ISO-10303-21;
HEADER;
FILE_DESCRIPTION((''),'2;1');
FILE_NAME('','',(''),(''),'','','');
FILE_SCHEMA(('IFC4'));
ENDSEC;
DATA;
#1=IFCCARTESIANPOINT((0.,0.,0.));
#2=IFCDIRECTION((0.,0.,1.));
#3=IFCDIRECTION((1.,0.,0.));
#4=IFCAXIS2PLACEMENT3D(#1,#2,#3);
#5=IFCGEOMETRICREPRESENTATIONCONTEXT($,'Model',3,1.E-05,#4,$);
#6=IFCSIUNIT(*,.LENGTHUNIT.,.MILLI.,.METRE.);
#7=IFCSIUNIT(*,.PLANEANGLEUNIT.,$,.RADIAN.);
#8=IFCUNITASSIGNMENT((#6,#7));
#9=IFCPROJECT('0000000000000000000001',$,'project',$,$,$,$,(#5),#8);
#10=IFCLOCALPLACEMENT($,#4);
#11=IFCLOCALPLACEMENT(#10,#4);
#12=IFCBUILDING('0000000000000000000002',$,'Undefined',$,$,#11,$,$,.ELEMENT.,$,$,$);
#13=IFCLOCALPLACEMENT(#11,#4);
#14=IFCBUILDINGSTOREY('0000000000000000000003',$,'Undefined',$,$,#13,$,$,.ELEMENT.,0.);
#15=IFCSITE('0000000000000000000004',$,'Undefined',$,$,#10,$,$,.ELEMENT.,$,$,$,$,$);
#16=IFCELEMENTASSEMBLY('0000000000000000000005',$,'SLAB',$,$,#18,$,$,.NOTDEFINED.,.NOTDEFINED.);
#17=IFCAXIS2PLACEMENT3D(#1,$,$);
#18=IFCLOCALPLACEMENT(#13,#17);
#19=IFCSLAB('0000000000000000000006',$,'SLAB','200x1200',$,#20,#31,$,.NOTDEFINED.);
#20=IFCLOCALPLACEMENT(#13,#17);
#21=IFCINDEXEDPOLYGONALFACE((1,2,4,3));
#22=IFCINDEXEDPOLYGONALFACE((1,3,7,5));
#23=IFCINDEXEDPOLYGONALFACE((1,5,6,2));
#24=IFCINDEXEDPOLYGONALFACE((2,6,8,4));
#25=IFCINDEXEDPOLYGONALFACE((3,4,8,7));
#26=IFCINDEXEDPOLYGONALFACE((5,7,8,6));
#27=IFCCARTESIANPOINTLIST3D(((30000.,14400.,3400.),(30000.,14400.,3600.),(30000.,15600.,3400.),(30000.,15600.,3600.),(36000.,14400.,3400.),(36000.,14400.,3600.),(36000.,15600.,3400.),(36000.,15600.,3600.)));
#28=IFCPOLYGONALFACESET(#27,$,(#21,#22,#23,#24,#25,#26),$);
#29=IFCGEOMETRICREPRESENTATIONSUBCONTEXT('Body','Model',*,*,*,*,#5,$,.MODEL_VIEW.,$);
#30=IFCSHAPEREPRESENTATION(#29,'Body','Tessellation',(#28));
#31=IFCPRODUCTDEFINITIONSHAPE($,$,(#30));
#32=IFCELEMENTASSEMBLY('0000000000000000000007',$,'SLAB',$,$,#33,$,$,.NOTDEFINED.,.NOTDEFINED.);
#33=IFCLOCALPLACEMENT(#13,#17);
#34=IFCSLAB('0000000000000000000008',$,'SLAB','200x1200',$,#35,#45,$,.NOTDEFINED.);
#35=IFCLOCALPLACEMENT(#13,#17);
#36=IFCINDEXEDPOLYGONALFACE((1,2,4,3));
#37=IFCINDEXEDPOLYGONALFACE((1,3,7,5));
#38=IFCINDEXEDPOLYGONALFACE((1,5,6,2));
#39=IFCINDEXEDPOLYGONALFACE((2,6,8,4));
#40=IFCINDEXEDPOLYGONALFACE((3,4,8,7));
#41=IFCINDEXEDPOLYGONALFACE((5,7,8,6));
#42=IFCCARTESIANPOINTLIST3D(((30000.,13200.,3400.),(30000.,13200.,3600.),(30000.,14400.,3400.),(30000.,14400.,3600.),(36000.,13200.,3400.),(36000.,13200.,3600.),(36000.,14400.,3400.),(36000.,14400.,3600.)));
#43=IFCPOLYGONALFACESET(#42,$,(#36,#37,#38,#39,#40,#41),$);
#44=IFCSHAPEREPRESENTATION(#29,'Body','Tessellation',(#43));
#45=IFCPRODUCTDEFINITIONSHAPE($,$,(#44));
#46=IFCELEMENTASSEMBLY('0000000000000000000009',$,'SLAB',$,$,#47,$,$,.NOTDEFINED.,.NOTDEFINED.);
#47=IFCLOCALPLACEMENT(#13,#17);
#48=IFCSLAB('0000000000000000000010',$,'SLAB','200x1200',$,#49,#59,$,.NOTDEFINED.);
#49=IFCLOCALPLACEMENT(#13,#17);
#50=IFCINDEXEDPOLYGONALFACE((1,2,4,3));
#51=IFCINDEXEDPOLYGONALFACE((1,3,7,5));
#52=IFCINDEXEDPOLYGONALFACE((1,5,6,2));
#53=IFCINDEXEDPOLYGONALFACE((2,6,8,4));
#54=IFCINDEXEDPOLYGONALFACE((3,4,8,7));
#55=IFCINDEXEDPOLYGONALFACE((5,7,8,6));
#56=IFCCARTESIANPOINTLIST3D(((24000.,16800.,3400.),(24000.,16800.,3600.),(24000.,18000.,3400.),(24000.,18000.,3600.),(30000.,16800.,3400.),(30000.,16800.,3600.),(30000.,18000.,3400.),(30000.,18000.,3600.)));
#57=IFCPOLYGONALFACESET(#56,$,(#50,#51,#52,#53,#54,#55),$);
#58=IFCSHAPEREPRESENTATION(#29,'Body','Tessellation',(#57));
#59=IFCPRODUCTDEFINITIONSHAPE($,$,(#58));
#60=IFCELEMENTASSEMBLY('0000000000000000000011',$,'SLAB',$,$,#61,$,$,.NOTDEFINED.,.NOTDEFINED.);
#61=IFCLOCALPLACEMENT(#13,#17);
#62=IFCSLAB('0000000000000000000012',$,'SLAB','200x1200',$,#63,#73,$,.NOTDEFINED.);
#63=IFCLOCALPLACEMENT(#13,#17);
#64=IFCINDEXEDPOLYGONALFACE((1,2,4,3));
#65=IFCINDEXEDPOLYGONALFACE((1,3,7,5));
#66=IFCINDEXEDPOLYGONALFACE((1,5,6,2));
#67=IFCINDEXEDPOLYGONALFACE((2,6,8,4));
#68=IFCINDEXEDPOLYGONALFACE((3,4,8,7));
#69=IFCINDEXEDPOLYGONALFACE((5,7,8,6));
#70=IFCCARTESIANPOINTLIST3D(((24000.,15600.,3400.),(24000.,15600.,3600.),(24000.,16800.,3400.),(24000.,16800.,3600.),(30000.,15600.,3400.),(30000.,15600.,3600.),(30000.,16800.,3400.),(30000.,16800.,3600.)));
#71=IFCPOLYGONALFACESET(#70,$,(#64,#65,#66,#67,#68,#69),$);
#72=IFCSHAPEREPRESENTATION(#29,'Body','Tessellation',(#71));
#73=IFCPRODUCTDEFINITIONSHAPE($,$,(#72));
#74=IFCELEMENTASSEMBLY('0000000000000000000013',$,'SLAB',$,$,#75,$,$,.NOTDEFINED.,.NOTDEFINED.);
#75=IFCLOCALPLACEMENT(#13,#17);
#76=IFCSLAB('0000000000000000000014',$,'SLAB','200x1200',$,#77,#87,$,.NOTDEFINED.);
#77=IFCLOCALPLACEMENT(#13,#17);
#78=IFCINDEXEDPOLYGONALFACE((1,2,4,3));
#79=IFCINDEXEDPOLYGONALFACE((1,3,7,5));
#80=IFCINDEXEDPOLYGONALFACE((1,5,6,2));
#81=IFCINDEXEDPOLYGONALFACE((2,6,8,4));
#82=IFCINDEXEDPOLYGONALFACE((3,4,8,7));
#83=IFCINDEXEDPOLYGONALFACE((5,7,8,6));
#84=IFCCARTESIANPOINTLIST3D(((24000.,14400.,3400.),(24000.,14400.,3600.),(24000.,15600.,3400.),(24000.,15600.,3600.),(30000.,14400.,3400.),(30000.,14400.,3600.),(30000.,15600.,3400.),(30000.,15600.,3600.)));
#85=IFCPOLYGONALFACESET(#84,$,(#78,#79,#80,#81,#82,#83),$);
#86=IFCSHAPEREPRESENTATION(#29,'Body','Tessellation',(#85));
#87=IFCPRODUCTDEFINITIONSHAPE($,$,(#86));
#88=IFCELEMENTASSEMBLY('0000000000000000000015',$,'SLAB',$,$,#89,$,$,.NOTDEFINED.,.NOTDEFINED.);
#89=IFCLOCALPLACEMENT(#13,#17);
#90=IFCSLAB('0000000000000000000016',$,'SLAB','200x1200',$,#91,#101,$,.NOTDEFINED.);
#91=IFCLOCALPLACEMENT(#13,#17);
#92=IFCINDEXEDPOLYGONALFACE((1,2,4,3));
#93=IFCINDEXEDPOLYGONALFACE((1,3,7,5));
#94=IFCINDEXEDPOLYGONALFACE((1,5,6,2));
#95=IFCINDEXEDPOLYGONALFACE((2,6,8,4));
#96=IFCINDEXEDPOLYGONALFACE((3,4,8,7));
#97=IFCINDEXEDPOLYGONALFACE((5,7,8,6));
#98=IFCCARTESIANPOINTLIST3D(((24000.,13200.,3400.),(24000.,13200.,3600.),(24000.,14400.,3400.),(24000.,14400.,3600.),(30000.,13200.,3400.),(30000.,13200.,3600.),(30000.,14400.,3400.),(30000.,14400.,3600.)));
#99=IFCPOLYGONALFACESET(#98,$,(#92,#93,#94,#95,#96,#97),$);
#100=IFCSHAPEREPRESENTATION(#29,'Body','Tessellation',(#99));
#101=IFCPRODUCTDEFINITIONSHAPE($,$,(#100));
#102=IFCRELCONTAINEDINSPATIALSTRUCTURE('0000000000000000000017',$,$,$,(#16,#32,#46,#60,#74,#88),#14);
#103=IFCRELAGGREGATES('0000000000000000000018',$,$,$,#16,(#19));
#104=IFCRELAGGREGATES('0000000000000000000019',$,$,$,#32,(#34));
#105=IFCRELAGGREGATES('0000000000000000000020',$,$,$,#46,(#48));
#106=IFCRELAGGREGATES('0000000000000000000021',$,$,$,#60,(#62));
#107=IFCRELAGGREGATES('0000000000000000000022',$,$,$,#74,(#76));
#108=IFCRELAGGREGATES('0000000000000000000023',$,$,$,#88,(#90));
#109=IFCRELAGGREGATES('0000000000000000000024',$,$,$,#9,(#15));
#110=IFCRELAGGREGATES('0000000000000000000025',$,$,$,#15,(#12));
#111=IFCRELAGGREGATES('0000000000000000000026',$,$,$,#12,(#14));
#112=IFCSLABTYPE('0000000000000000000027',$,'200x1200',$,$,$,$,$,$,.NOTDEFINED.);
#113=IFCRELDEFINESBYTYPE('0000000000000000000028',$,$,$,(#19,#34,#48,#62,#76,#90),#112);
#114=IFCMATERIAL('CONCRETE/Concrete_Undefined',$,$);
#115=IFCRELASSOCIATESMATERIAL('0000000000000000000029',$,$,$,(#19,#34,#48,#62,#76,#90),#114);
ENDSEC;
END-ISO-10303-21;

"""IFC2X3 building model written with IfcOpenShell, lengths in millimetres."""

from ifc_helpers import new_model, si_unit, frame, origin_with_axes, place, context, subcontext, project, spatial, polyline, outline, extrude, material, type_object, element, aggregate, save


model = new_model("IFC2X3")

# Units and contexts
model_context = context("Model", 3, precision=1e-05, world=origin_with_axes())
body_context = subcontext(model_context, "Body", "Model", "MODEL_VIEW")
ifc_project = project(units=[si_unit("LENGTHUNIT", "METRE", prefix="MILLI"), si_unit("PLANEANGLEUNIT", "RADIAN")], contexts=[model_context])

# Site, building, storey
site_placement = place(None, origin_with_axes())
site = spatial("IfcSite", under=ifc_project, at=site_placement, Name="Undefined", CompositionType="ELEMENT")
building_placement = place(site_placement, origin_with_axes())
building = spatial("IfcBuilding", under=site, at=building_placement, Name="Undefined", CompositionType="ELEMENT")
storey_placement = place(building_placement, origin_with_axes())
storey = spatial("IfcBuildingStorey", under=building, at=storey_placement, Name="Undefined", CompositionType="ELEMENT", Elevation=0.0)

# Shared definitions
ifc_material = material(Name="CONCRETE/Concrete_Undefined")

# Element assemblies, slabs
slab_type = type_object("IfcSlabType", Name="200x1200", PredefinedType="NOTDEFINED")
assembly_1_placement = place(storey_placement, origin_with_axes())
assembly_1 = element("IfcElementAssembly", 1, at=assembly_1_placement, inside=storey, Name="SLAB", AssemblyPlace="NOTDEFINED", PredefinedType="NOTDEFINED")
slab_1_placement = place(assembly_1_placement, frame((36000.0, 14400.0, 3500.0), z_axis=(0.0, 0.0, 1.0), x_axis=(0.0, 1.0, 0.0)))
slab_1 = element("IfcSlab", 2, at=slab_1_placement, type_object=slab_type, material=ifc_material, Name="SLAB", Description="200x1200", PredefinedType="NOTDEFINED", context=body_context, shape_type="SweptSolid", body=[
    extrude(outline(polyline([(0.0, 0.0), (1200.0, 0.0), (1200.0, 6000.0), (0.0, 6000.0), (0.0, 0.0)])), frame((0.0, 0.0, -100.0), z_axis=(0.0, 0.0, 1.0), x_axis=(1.0, 0.0, 0.0)), (0.0, 0.0, 1.0), 200.0),
])
aggregate(assembly_1, [slab_1])
assembly_2_placement = place(storey_placement, origin_with_axes())
assembly_2 = element("IfcElementAssembly", 3, at=assembly_2_placement, inside=storey, Name="SLAB", AssemblyPlace="NOTDEFINED", PredefinedType="NOTDEFINED")
slab_2_placement = place(assembly_2_placement, frame((36000.0, 13200.0, 3500.0), z_axis=(0.0, 0.0, 1.0), x_axis=(0.0, 1.0, 0.0)))
slab_2 = element("IfcSlab", 4, at=slab_2_placement, type_object=slab_type, material=ifc_material, Name="SLAB", Description="200x1200", PredefinedType="NOTDEFINED", context=body_context, shape_type="SweptSolid", body=[
    extrude(outline(polyline([(0.0, 0.0), (1200.0, 0.0), (1200.0, 6000.0), (0.0, 6000.0), (0.0, 0.0)])), frame((0.0, 0.0, -100.0), z_axis=(0.0, 0.0, 1.0), x_axis=(1.0, 0.0, 0.0)), (0.0, 0.0, 1.0), 200.0),
])
aggregate(assembly_2, [slab_2])
assembly_3_placement = place(storey_placement, origin_with_axes())
assembly_3 = element("IfcElementAssembly", 5, at=assembly_3_placement, inside=storey, Name="SLAB", AssemblyPlace="NOTDEFINED", PredefinedType="NOTDEFINED")
slab_3_placement = place(assembly_3_placement, frame((30000.0, 16800.0, 3500.0), z_axis=(0.0, 0.0, 1.0), x_axis=(0.0, 1.0, 0.0)))
slab_3 = element("IfcSlab", 6, at=slab_3_placement, type_object=slab_type, material=ifc_material, Name="SLAB", Description="200x1200", PredefinedType="NOTDEFINED", context=body_context, shape_type="SweptSolid", body=[
    extrude(outline(polyline([(0.0, 0.0), (1200.0, 0.0), (1200.0, 6000.0), (0.0, 6000.0), (0.0, 0.0)])), frame((0.0, 0.0, -100.0), z_axis=(0.0, 0.0, 1.0), x_axis=(1.0, 0.0, 0.0)), (0.0, 0.0, 1.0), 200.0),
])
aggregate(assembly_3, [slab_3])
assembly_4_placement = place(storey_placement, origin_with_axes())
assembly_4 = element("IfcElementAssembly", 7, at=assembly_4_placement, inside=storey, Name="SLAB", AssemblyPlace="NOTDEFINED", PredefinedType="NOTDEFINED")
slab_4_placement = place(assembly_4_placement, frame((30000.0, 15600.0, 3500.0), z_axis=(0.0, 0.0, 1.0), x_axis=(0.0, 1.0, 0.0)))
slab_4 = element("IfcSlab", 8, at=slab_4_placement, type_object=slab_type, material=ifc_material, Name="SLAB", Description="200x1200", PredefinedType="NOTDEFINED", context=body_context, shape_type="SweptSolid", body=[
    extrude(outline(polyline([(0.0, 0.0), (1200.0, 0.0), (1200.0, 6000.0), (0.0, 6000.0), (0.0, 0.0)])), frame((0.0, 0.0, -100.0), z_axis=(0.0, 0.0, 1.0), x_axis=(1.0, 0.0, 0.0)), (0.0, 0.0, 1.0), 200.0),
])
aggregate(assembly_4, [slab_4])
assembly_5_placement = place(storey_placement, origin_with_axes())
assembly_5 = element("IfcElementAssembly", 9, at=assembly_5_placement, inside=storey, Name="SLAB", AssemblyPlace="NOTDEFINED", PredefinedType="NOTDEFINED")
slab_5_placement = place(assembly_5_placement, frame((30000.0, 14400.0, 3500.0), z_axis=(0.0, 0.0, 1.0), x_axis=(0.0, 1.0, 0.0)))
slab_5 = element("IfcSlab", 10, at=slab_5_placement, type_object=slab_type, material=ifc_material, Name="SLAB", Description="200x1200", PredefinedType="NOTDEFINED", context=body_context, shape_type="SweptSolid", body=[
    extrude(outline(polyline([(0.0, 0.0), (1200.0, 0.0), (1200.0, 6000.0), (0.0, 6000.0), (0.0, 0.0)])), frame((0.0, 0.0, -100.0), z_axis=(0.0, 0.0, 1.0), x_axis=(1.0, 0.0, 0.0)), (0.0, 0.0, 1.0), 200.0),
])
aggregate(assembly_5, [slab_5])
assembly_6_placement = place(storey_placement, origin_with_axes())
assembly_6 = element("IfcElementAssembly", 11, at=assembly_6_placement, inside=storey, Name="SLAB", AssemblyPlace="NOTDEFINED", PredefinedType="NOTDEFINED")
slab_6_placement = place(assembly_6_placement, frame((30000.0, 13200.0, 3500.0), z_axis=(0.0, 0.0, 1.0), x_axis=(0.0, 1.0, 0.0)))
slab_6 = element("IfcSlab", 12, at=slab_6_placement, type_object=slab_type, material=ifc_material, Name="SLAB", Description="200x1200", PredefinedType="NOTDEFINED", context=body_context, shape_type="SweptSolid", body=[
    extrude(outline(polyline([(0.0, 0.0), (1200.0, 0.0), (1200.0, 6000.0), (0.0, 6000.0), (0.0, 0.0)])), frame((0.0, 0.0, -100.0), z_axis=(0.0, 0.0, 1.0), x_axis=(1.0, 0.0, 0.0)), (0.0, 0.0, 1.0), 200.0),
])
aggregate(assembly_6, [slab_6])

save(model, "model.ifc")
